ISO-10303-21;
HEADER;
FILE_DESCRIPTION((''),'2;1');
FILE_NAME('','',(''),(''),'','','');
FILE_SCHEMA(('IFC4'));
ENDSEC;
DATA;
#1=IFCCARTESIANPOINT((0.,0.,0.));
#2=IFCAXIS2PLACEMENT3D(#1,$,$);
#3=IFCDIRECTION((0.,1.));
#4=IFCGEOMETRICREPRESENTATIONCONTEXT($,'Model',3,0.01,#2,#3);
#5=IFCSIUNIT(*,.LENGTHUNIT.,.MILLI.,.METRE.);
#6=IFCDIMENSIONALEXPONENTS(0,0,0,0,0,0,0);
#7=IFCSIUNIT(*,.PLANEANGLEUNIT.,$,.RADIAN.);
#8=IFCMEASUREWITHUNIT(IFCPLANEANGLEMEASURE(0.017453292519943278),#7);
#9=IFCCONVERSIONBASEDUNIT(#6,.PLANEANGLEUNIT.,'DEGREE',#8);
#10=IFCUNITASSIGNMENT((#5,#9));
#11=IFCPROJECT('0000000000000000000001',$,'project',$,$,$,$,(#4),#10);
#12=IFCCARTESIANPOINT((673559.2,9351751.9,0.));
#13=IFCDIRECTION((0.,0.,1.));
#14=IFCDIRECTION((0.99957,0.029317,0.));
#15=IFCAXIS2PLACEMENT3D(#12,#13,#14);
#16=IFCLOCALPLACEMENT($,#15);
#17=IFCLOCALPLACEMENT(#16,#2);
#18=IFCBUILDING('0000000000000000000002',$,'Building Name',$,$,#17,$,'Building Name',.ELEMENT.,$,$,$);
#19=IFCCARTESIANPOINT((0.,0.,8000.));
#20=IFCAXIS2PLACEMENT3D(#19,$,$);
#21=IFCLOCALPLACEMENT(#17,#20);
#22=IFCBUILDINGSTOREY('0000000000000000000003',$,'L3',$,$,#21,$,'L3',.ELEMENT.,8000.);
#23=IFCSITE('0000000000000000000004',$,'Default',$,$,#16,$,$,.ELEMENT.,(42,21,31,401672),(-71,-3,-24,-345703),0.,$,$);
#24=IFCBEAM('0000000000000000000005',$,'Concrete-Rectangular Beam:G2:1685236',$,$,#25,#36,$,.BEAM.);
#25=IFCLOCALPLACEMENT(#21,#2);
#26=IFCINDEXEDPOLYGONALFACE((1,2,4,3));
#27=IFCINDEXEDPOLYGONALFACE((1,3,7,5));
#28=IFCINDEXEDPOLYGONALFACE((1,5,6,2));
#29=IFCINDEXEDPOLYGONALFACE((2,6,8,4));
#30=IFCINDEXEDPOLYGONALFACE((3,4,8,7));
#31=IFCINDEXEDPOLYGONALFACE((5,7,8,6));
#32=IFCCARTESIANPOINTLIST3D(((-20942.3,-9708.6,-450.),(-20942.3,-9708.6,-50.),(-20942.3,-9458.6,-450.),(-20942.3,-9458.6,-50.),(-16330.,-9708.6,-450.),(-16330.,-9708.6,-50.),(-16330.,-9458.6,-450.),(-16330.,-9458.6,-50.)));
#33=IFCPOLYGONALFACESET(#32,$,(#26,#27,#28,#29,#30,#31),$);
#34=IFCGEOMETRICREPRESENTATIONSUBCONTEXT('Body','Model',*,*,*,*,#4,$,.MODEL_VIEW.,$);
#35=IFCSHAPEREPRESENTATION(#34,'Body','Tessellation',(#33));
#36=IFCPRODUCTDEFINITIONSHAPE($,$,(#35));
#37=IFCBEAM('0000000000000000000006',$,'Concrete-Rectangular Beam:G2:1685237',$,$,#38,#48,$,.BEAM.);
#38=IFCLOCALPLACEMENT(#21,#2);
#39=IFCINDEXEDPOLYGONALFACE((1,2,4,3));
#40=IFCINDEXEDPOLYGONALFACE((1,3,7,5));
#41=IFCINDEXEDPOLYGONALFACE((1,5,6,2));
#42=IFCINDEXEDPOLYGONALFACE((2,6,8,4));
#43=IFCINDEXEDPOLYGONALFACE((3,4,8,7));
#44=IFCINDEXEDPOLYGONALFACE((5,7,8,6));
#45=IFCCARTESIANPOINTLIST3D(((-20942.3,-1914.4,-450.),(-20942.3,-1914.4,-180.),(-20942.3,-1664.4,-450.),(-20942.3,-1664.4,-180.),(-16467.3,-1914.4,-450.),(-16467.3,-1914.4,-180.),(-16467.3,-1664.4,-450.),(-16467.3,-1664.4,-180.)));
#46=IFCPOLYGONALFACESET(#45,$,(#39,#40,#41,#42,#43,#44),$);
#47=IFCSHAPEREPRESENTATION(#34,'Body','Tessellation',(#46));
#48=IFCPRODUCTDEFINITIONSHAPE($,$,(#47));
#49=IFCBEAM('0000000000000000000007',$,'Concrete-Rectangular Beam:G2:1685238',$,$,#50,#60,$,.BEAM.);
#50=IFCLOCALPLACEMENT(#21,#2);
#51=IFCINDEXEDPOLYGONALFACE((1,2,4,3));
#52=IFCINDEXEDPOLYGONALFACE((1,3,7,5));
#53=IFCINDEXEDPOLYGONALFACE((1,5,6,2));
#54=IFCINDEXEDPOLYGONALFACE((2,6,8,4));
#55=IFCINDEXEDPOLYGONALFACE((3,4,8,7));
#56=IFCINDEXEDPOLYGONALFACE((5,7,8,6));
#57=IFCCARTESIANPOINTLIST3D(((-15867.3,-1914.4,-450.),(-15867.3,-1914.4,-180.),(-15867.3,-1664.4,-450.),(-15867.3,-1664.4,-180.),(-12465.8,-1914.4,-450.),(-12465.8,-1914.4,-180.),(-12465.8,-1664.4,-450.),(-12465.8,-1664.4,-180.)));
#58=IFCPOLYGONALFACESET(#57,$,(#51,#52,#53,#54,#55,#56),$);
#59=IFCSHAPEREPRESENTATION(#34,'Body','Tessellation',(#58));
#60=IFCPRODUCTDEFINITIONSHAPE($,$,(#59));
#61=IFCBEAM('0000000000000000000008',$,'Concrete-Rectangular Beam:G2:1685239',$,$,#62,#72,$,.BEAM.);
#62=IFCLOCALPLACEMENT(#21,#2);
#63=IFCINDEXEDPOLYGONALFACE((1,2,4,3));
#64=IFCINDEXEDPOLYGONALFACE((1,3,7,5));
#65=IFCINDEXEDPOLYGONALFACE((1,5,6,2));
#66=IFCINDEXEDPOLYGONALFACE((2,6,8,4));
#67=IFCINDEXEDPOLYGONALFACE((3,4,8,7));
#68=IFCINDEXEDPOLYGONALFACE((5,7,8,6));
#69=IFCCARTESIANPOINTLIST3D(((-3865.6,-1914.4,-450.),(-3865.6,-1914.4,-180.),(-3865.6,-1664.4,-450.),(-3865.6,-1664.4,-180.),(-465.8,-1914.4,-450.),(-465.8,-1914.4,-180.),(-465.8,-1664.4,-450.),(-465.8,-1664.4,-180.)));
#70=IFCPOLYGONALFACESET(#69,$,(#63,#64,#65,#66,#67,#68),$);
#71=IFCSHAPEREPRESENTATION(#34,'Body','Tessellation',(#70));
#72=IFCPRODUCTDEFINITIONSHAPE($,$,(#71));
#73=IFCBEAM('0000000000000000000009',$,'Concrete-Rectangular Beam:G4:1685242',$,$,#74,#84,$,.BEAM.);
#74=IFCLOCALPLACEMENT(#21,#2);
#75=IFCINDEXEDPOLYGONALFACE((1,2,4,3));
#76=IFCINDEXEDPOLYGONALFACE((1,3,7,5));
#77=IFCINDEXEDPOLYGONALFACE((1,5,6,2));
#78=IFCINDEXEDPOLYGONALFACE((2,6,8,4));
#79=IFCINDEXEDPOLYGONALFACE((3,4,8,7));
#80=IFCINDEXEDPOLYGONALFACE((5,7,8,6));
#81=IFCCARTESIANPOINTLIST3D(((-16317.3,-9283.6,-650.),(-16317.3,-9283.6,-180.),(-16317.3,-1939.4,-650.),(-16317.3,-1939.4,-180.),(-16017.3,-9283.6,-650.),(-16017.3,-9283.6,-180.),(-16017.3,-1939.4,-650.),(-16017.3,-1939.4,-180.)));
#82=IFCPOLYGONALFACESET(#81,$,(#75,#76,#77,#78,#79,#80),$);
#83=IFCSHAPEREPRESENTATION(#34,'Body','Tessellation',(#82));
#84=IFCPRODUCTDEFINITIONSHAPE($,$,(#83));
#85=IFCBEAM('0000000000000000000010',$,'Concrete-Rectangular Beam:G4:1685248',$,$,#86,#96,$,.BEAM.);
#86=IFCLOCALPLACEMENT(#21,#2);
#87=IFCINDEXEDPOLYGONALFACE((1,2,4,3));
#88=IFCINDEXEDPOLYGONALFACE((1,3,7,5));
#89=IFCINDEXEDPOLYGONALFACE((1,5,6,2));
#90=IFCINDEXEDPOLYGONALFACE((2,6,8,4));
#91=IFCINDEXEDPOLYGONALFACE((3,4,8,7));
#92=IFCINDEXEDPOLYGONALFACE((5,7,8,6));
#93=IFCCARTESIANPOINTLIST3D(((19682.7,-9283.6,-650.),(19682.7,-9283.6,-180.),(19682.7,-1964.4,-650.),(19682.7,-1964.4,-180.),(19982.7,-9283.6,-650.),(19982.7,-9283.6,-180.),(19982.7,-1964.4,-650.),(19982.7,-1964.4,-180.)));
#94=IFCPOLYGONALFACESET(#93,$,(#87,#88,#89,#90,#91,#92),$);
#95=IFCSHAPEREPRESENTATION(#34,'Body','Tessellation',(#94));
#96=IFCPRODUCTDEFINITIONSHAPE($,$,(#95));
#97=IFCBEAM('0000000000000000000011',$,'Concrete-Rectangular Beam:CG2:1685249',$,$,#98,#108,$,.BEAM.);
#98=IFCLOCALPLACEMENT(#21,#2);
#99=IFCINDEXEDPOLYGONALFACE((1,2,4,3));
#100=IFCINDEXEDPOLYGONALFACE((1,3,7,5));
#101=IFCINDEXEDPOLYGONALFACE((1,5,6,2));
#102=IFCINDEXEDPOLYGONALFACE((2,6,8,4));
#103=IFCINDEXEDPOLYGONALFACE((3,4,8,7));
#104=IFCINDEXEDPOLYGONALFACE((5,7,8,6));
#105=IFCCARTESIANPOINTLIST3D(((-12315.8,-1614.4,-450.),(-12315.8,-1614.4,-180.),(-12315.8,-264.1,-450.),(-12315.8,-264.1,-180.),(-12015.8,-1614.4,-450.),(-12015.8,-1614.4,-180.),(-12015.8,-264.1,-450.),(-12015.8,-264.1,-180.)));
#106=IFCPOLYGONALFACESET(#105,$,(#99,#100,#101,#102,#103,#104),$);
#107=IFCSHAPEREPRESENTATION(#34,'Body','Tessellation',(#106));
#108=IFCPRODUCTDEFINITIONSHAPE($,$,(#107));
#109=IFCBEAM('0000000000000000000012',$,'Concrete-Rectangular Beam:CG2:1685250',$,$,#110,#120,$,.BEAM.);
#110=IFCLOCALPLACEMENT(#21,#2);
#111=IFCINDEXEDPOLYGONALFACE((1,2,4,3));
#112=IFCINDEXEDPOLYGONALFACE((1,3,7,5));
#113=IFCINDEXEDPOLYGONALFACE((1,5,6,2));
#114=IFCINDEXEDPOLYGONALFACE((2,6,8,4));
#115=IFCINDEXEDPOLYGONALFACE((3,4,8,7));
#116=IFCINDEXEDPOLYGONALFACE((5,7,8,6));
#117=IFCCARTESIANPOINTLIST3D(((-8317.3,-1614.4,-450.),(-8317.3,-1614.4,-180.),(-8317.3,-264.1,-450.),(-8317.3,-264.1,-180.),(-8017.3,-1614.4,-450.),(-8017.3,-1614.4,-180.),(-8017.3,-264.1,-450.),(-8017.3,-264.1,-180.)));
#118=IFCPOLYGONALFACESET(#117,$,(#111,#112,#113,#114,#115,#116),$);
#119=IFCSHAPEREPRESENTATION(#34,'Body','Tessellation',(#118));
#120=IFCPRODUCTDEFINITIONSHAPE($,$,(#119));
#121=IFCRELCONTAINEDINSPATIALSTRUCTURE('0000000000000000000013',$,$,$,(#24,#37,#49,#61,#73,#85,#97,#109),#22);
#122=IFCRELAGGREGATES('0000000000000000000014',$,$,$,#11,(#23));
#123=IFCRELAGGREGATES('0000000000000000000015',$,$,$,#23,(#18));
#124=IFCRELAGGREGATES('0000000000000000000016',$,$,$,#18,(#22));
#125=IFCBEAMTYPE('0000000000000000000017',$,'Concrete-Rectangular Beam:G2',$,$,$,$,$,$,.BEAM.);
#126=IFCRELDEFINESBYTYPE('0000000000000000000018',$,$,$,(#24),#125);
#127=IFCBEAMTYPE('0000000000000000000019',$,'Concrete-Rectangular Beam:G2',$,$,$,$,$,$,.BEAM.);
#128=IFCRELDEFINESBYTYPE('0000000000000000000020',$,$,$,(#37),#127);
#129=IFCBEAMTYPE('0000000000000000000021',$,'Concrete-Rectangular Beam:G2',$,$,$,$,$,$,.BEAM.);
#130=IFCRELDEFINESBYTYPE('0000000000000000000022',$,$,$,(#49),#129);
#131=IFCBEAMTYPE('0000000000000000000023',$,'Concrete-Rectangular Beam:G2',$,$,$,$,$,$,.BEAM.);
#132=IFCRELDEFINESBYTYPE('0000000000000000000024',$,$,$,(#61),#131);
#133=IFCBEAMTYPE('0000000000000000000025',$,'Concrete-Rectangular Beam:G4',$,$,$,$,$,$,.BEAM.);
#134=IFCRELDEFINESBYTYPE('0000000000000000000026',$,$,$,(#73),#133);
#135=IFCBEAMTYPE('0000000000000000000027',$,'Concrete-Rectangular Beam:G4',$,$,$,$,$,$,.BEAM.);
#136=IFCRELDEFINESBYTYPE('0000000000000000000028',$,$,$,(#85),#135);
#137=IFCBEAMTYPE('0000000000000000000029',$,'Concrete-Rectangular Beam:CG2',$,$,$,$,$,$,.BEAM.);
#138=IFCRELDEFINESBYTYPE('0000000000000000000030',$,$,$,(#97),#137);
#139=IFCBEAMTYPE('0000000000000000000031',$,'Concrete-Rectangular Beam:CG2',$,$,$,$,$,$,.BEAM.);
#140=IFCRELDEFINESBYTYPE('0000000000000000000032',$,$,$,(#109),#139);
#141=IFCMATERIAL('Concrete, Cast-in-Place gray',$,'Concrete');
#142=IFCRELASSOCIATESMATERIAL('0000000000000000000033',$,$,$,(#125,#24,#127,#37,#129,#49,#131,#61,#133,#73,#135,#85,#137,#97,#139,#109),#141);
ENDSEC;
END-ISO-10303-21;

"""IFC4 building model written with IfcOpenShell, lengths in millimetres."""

from ifc_helpers import new_model, entity, si_unit, converted_unit, direction, frame, origin, place, context, subcontext, project, spatial, indexed_curve, outline, extrude, source, transform, mapped, material, type_object, type_shapes, element, save


model = new_model("IFC4")

# Units and contexts
model_context = context("Model", 3, precision=0.01, world=origin(), true_north=direction((0.0, 1.0)))
body_context = subcontext(model_context, "Body", "Model", "MODEL_VIEW")
ifc_project = project(units=[si_unit("LENGTHUNIT", "METRE", prefix="MILLI"), converted_unit("PLANEANGLEUNIT", "DEGREE", entity("IfcPlaneAngleMeasure", 0.017453292519943278), si_unit("PLANEANGLEUNIT", "RADIAN"), dimensions=[0, 0, 0, 0, 0, 0, 0])], contexts=[model_context])

# Site, building, storey
site_placement = place(None, frame((673559.2, 9351751.9, 0.0), z_axis=(0.0, 0.0, 1.0), x_axis=(0.99957, 0.029317, 0.0)))
site = spatial("IfcSite", under=ifc_project, at=site_placement, Name="Default", CompositionType="ELEMENT", RefLatitude=(42, 21, 31, 401672), RefLongitude=(-71, -3, -24, -345703), RefElevation=0.0)
building_placement = place(site_placement, origin())
building = spatial("IfcBuilding", under=site, at=building_placement, Name="Building Name", LongName="Building Name", CompositionType="ELEMENT")
storey_placement = place(building_placement, frame((0.0, 0.0, 8000.0)))
storey = spatial("IfcBuildingStorey", under=building, at=storey_placement, Name="L3", LongName="L3", CompositionType="ELEMENT", Elevation=8000.0)

# Shared definitions
ifc_material = material(Name="Concrete, Cast-in-Place gray", Category="Concrete")

# Beams
beam_type_1 = type_object("IfcBeamType", Name="Concrete-Rectangular Beam:G2", PredefinedType="BEAM", material=ifc_material)
shared_shape_1 = source(origin(), body_context, "Body", "SweptSolid", [
    extrude(outline(indexed_curve([(-200.0, -125.0), (200.0, -125.0), (200.0, 125.0), (-200.0, 125.0), (-200.0, -125.0)], self_intersect=False)), frame((-16330.0, -9583.6, 7750.0), z_axis=(-1.0, 0.0, 0.0), x_axis=(0.0, 0.0, -1.0)), (0.0, 0.0, 1.0), 4612.3),
])
type_shapes(beam_type_1, [shared_shape_1])
beam_1_placement = place(storey_placement, frame((0.0, 0.0, -8000.0)))
element("IfcBeam", 1, at=beam_1_placement, inside=storey, type_object=beam_type_1, material=ifc_material, Name="Concrete-Rectangular Beam:G2:1685236", PredefinedType="BEAM", context=body_context, shape_type="MappedRepresentation", body=[
    mapped(shared_shape_1, transform((0.0, 0.0, 0.0), scale=1.0)),
])
beam_type_2 = type_object("IfcBeamType", Name="Concrete-Rectangular Beam:G2", PredefinedType="BEAM", material=ifc_material)
shared_shape_2 = source(origin(), body_context, "Body", "SweptSolid", [
    extrude(outline(indexed_curve([(-135.0, -125.0), (135.0, -125.0), (135.0, 125.0), (-135.0, 125.0), (-135.0, -125.0)], self_intersect=False)), frame((-20942.3, -1789.4, 7685.0), z_axis=(1.0, 0.0, 0.0), x_axis=(0.0, 0.0, -1.0)), (0.0, 0.0, 1.0), 4475.0),
])
type_shapes(beam_type_2, [shared_shape_2])
beam_2_placement = place(storey_placement, frame((0.0, 0.0, -8000.0)))
element("IfcBeam", 2, at=beam_2_placement, inside=storey, type_object=beam_type_2, material=ifc_material, Name="Concrete-Rectangular Beam:G2:1685237", PredefinedType="BEAM", context=body_context, shape_type="MappedRepresentation", body=[
    mapped(shared_shape_2, transform((0.0, 0.0, 0.0), scale=1.0)),
])
beam_type_3 = type_object("IfcBeamType", Name="Concrete-Rectangular Beam:G2", PredefinedType="BEAM", material=ifc_material)
shared_shape_3 = source(origin(), body_context, "Body", "SweptSolid", [
    extrude(outline(indexed_curve([(-135.0, -125.0), (135.0, -125.0), (135.0, 125.0), (-135.0, 125.0), (-135.0, -125.0)], self_intersect=False)), frame((-15867.3, -1789.4, 7685.0), z_axis=(1.0, 0.0, 0.0), x_axis=(0.0, 0.0, -1.0)), (0.0, 0.0, 1.0), 3401.5),
])
type_shapes(beam_type_3, [shared_shape_3])
beam_3_placement = place(storey_placement, frame((0.0, 0.0, -8000.0)))
element("IfcBeam", 3, at=beam_3_placement, inside=storey, type_object=beam_type_3, material=ifc_material, Name="Concrete-Rectangular Beam:G2:1685238", PredefinedType="BEAM", context=body_context, shape_type="MappedRepresentation", body=[
    mapped(shared_shape_3, transform((0.0, 0.0, 0.0), scale=1.0)),
])
beam_type_4 = type_object("IfcBeamType", Name="Concrete-Rectangular Beam:G2", PredefinedType="BEAM", material=ifc_material)
shared_shape_4 = source(origin(), body_context, "Body", "SweptSolid", [
    extrude(outline(indexed_curve([(-135.0, -125.0), (135.0, -125.0), (135.0, 125.0), (-135.0, 125.0), (-135.0, -125.0)], self_intersect=False)), frame((-465.8, -1789.4, 7685.0), z_axis=(-1.0, 0.0, 0.0), x_axis=(0.0, 0.0, -1.0)), (0.0, 0.0, 1.0), 3399.7),
])
type_shapes(beam_type_4, [shared_shape_4])
beam_4_placement = place(storey_placement, frame((0.0, 0.0, -8000.0)))
element("IfcBeam", 4, at=beam_4_placement, inside=storey, type_object=beam_type_4, material=ifc_material, Name="Concrete-Rectangular Beam:G2:1685239", PredefinedType="BEAM", context=body_context, shape_type="MappedRepresentation", body=[
    mapped(shared_shape_4, transform((0.0, 0.0, 0.0), scale=1.0)),
])
beam_type_5 = type_object("IfcBeamType", Name="Concrete-Rectangular Beam:G4", PredefinedType="BEAM", material=ifc_material)
shared_shape_5 = source(origin(), body_context, "Body", "SweptSolid", [
    extrude(outline(indexed_curve([(-150.0, -235.0), (150.0, -235.0), (150.0, 235.0), (-150.0, 235.0), (-150.0, -235.0)], self_intersect=False)), frame((-16167.3, -9283.6, 7585.0), z_axis=(0.0, 1.0, 0.0), x_axis=(-1.0, 0.0, 0.0)), (0.0, 0.0, 1.0), 7344.1),
])
type_shapes(beam_type_5, [shared_shape_5])
beam_5_placement = place(storey_placement, frame((0.0, 0.0, -8000.0)))
element("IfcBeam", 5, at=beam_5_placement, inside=storey, type_object=beam_type_5, material=ifc_material, Name="Concrete-Rectangular Beam:G4:1685242", PredefinedType="BEAM", context=body_context, shape_type="MappedRepresentation", body=[
    mapped(shared_shape_5, transform((0.0, 0.0, 0.0), scale=1.0)),
])
beam_type_6 = type_object("IfcBeamType", Name="Concrete-Rectangular Beam:G4", PredefinedType="BEAM", material=ifc_material)
shared_shape_6 = source(origin(), body_context, "Body", "SweptSolid", [
    extrude(outline(indexed_curve([(-150.0, -235.0), (150.0, -235.0), (150.0, 235.0), (-150.0, 235.0), (-150.0, -235.0)], self_intersect=False)), frame((19832.7, -9283.6, 7585.0), z_axis=(0.0, 1.0, 0.0), x_axis=(-1.0, 0.0, 0.0)), (0.0, 0.0, 1.0), 7319.1),
])
type_shapes(beam_type_6, [shared_shape_6])
beam_6_placement = place(storey_placement, frame((0.0, 0.0, -8000.0)))
element("IfcBeam", 6, at=beam_6_placement, inside=storey, type_object=beam_type_6, material=ifc_material, Name="Concrete-Rectangular Beam:G4:1685248", PredefinedType="BEAM", context=body_context, shape_type="MappedRepresentation", body=[
    mapped(shared_shape_6, transform((0.0, 0.0, 0.0), scale=1.0)),
])
beam_type_7 = type_object("IfcBeamType", Name="Concrete-Rectangular Beam:CG2", PredefinedType="BEAM", material=ifc_material)
shared_shape_7 = source(origin(), body_context, "Body", "SweptSolid", [
    extrude(outline(indexed_curve([(-150.0, -135.0), (150.0, -135.0), (150.0, 135.0), (-150.0, 135.0), (-150.0, -135.0)], self_intersect=False)), frame((-12165.8, -1614.4, 7685.0), z_axis=(0.0, 1.0, 0.0), x_axis=(-1.0, 0.0, 0.0)), (0.0, 0.0, 1.0), 1350.4),
])
type_shapes(beam_type_7, [shared_shape_7])
beam_7_placement = place(storey_placement, frame((0.0, 0.0, -8000.0)))
element("IfcBeam", 7, at=beam_7_placement, inside=storey, type_object=beam_type_7, material=ifc_material, Name="Concrete-Rectangular Beam:CG2:1685249", PredefinedType="BEAM", context=body_context, shape_type="MappedRepresentation", body=[
    mapped(shared_shape_7, transform((0.0, 0.0, 0.0), scale=1.0)),
])
beam_type_8 = type_object("IfcBeamType", Name="Concrete-Rectangular Beam:CG2", PredefinedType="BEAM", material=ifc_material)
shared_shape_8 = source(origin(), body_context, "Body", "SweptSolid", [
    extrude(outline(indexed_curve([(-150.0, -135.0), (150.0, -135.0), (150.0, 135.0), (-150.0, 135.0), (-150.0, -135.0)], self_intersect=False)), frame((-8167.3, -1614.4, 7685.0), z_axis=(0.0, 1.0, 0.0), x_axis=(-1.0, 0.0, 0.0)), (0.0, 0.0, 1.0), 1350.4),
])
type_shapes(beam_type_8, [shared_shape_8])
beam_8_placement = place(storey_placement, frame((0.0, 0.0, -8000.0)))
element("IfcBeam", 8, at=beam_8_placement, inside=storey, type_object=beam_type_8, material=ifc_material, Name="Concrete-Rectangular Beam:CG2:1685250", PredefinedType="BEAM", context=body_context, shape_type="MappedRepresentation", body=[
    mapped(shared_shape_8, transform((0.0, 0.0, 0.0), scale=1.0)),
])

save(model, "model.ifc")
